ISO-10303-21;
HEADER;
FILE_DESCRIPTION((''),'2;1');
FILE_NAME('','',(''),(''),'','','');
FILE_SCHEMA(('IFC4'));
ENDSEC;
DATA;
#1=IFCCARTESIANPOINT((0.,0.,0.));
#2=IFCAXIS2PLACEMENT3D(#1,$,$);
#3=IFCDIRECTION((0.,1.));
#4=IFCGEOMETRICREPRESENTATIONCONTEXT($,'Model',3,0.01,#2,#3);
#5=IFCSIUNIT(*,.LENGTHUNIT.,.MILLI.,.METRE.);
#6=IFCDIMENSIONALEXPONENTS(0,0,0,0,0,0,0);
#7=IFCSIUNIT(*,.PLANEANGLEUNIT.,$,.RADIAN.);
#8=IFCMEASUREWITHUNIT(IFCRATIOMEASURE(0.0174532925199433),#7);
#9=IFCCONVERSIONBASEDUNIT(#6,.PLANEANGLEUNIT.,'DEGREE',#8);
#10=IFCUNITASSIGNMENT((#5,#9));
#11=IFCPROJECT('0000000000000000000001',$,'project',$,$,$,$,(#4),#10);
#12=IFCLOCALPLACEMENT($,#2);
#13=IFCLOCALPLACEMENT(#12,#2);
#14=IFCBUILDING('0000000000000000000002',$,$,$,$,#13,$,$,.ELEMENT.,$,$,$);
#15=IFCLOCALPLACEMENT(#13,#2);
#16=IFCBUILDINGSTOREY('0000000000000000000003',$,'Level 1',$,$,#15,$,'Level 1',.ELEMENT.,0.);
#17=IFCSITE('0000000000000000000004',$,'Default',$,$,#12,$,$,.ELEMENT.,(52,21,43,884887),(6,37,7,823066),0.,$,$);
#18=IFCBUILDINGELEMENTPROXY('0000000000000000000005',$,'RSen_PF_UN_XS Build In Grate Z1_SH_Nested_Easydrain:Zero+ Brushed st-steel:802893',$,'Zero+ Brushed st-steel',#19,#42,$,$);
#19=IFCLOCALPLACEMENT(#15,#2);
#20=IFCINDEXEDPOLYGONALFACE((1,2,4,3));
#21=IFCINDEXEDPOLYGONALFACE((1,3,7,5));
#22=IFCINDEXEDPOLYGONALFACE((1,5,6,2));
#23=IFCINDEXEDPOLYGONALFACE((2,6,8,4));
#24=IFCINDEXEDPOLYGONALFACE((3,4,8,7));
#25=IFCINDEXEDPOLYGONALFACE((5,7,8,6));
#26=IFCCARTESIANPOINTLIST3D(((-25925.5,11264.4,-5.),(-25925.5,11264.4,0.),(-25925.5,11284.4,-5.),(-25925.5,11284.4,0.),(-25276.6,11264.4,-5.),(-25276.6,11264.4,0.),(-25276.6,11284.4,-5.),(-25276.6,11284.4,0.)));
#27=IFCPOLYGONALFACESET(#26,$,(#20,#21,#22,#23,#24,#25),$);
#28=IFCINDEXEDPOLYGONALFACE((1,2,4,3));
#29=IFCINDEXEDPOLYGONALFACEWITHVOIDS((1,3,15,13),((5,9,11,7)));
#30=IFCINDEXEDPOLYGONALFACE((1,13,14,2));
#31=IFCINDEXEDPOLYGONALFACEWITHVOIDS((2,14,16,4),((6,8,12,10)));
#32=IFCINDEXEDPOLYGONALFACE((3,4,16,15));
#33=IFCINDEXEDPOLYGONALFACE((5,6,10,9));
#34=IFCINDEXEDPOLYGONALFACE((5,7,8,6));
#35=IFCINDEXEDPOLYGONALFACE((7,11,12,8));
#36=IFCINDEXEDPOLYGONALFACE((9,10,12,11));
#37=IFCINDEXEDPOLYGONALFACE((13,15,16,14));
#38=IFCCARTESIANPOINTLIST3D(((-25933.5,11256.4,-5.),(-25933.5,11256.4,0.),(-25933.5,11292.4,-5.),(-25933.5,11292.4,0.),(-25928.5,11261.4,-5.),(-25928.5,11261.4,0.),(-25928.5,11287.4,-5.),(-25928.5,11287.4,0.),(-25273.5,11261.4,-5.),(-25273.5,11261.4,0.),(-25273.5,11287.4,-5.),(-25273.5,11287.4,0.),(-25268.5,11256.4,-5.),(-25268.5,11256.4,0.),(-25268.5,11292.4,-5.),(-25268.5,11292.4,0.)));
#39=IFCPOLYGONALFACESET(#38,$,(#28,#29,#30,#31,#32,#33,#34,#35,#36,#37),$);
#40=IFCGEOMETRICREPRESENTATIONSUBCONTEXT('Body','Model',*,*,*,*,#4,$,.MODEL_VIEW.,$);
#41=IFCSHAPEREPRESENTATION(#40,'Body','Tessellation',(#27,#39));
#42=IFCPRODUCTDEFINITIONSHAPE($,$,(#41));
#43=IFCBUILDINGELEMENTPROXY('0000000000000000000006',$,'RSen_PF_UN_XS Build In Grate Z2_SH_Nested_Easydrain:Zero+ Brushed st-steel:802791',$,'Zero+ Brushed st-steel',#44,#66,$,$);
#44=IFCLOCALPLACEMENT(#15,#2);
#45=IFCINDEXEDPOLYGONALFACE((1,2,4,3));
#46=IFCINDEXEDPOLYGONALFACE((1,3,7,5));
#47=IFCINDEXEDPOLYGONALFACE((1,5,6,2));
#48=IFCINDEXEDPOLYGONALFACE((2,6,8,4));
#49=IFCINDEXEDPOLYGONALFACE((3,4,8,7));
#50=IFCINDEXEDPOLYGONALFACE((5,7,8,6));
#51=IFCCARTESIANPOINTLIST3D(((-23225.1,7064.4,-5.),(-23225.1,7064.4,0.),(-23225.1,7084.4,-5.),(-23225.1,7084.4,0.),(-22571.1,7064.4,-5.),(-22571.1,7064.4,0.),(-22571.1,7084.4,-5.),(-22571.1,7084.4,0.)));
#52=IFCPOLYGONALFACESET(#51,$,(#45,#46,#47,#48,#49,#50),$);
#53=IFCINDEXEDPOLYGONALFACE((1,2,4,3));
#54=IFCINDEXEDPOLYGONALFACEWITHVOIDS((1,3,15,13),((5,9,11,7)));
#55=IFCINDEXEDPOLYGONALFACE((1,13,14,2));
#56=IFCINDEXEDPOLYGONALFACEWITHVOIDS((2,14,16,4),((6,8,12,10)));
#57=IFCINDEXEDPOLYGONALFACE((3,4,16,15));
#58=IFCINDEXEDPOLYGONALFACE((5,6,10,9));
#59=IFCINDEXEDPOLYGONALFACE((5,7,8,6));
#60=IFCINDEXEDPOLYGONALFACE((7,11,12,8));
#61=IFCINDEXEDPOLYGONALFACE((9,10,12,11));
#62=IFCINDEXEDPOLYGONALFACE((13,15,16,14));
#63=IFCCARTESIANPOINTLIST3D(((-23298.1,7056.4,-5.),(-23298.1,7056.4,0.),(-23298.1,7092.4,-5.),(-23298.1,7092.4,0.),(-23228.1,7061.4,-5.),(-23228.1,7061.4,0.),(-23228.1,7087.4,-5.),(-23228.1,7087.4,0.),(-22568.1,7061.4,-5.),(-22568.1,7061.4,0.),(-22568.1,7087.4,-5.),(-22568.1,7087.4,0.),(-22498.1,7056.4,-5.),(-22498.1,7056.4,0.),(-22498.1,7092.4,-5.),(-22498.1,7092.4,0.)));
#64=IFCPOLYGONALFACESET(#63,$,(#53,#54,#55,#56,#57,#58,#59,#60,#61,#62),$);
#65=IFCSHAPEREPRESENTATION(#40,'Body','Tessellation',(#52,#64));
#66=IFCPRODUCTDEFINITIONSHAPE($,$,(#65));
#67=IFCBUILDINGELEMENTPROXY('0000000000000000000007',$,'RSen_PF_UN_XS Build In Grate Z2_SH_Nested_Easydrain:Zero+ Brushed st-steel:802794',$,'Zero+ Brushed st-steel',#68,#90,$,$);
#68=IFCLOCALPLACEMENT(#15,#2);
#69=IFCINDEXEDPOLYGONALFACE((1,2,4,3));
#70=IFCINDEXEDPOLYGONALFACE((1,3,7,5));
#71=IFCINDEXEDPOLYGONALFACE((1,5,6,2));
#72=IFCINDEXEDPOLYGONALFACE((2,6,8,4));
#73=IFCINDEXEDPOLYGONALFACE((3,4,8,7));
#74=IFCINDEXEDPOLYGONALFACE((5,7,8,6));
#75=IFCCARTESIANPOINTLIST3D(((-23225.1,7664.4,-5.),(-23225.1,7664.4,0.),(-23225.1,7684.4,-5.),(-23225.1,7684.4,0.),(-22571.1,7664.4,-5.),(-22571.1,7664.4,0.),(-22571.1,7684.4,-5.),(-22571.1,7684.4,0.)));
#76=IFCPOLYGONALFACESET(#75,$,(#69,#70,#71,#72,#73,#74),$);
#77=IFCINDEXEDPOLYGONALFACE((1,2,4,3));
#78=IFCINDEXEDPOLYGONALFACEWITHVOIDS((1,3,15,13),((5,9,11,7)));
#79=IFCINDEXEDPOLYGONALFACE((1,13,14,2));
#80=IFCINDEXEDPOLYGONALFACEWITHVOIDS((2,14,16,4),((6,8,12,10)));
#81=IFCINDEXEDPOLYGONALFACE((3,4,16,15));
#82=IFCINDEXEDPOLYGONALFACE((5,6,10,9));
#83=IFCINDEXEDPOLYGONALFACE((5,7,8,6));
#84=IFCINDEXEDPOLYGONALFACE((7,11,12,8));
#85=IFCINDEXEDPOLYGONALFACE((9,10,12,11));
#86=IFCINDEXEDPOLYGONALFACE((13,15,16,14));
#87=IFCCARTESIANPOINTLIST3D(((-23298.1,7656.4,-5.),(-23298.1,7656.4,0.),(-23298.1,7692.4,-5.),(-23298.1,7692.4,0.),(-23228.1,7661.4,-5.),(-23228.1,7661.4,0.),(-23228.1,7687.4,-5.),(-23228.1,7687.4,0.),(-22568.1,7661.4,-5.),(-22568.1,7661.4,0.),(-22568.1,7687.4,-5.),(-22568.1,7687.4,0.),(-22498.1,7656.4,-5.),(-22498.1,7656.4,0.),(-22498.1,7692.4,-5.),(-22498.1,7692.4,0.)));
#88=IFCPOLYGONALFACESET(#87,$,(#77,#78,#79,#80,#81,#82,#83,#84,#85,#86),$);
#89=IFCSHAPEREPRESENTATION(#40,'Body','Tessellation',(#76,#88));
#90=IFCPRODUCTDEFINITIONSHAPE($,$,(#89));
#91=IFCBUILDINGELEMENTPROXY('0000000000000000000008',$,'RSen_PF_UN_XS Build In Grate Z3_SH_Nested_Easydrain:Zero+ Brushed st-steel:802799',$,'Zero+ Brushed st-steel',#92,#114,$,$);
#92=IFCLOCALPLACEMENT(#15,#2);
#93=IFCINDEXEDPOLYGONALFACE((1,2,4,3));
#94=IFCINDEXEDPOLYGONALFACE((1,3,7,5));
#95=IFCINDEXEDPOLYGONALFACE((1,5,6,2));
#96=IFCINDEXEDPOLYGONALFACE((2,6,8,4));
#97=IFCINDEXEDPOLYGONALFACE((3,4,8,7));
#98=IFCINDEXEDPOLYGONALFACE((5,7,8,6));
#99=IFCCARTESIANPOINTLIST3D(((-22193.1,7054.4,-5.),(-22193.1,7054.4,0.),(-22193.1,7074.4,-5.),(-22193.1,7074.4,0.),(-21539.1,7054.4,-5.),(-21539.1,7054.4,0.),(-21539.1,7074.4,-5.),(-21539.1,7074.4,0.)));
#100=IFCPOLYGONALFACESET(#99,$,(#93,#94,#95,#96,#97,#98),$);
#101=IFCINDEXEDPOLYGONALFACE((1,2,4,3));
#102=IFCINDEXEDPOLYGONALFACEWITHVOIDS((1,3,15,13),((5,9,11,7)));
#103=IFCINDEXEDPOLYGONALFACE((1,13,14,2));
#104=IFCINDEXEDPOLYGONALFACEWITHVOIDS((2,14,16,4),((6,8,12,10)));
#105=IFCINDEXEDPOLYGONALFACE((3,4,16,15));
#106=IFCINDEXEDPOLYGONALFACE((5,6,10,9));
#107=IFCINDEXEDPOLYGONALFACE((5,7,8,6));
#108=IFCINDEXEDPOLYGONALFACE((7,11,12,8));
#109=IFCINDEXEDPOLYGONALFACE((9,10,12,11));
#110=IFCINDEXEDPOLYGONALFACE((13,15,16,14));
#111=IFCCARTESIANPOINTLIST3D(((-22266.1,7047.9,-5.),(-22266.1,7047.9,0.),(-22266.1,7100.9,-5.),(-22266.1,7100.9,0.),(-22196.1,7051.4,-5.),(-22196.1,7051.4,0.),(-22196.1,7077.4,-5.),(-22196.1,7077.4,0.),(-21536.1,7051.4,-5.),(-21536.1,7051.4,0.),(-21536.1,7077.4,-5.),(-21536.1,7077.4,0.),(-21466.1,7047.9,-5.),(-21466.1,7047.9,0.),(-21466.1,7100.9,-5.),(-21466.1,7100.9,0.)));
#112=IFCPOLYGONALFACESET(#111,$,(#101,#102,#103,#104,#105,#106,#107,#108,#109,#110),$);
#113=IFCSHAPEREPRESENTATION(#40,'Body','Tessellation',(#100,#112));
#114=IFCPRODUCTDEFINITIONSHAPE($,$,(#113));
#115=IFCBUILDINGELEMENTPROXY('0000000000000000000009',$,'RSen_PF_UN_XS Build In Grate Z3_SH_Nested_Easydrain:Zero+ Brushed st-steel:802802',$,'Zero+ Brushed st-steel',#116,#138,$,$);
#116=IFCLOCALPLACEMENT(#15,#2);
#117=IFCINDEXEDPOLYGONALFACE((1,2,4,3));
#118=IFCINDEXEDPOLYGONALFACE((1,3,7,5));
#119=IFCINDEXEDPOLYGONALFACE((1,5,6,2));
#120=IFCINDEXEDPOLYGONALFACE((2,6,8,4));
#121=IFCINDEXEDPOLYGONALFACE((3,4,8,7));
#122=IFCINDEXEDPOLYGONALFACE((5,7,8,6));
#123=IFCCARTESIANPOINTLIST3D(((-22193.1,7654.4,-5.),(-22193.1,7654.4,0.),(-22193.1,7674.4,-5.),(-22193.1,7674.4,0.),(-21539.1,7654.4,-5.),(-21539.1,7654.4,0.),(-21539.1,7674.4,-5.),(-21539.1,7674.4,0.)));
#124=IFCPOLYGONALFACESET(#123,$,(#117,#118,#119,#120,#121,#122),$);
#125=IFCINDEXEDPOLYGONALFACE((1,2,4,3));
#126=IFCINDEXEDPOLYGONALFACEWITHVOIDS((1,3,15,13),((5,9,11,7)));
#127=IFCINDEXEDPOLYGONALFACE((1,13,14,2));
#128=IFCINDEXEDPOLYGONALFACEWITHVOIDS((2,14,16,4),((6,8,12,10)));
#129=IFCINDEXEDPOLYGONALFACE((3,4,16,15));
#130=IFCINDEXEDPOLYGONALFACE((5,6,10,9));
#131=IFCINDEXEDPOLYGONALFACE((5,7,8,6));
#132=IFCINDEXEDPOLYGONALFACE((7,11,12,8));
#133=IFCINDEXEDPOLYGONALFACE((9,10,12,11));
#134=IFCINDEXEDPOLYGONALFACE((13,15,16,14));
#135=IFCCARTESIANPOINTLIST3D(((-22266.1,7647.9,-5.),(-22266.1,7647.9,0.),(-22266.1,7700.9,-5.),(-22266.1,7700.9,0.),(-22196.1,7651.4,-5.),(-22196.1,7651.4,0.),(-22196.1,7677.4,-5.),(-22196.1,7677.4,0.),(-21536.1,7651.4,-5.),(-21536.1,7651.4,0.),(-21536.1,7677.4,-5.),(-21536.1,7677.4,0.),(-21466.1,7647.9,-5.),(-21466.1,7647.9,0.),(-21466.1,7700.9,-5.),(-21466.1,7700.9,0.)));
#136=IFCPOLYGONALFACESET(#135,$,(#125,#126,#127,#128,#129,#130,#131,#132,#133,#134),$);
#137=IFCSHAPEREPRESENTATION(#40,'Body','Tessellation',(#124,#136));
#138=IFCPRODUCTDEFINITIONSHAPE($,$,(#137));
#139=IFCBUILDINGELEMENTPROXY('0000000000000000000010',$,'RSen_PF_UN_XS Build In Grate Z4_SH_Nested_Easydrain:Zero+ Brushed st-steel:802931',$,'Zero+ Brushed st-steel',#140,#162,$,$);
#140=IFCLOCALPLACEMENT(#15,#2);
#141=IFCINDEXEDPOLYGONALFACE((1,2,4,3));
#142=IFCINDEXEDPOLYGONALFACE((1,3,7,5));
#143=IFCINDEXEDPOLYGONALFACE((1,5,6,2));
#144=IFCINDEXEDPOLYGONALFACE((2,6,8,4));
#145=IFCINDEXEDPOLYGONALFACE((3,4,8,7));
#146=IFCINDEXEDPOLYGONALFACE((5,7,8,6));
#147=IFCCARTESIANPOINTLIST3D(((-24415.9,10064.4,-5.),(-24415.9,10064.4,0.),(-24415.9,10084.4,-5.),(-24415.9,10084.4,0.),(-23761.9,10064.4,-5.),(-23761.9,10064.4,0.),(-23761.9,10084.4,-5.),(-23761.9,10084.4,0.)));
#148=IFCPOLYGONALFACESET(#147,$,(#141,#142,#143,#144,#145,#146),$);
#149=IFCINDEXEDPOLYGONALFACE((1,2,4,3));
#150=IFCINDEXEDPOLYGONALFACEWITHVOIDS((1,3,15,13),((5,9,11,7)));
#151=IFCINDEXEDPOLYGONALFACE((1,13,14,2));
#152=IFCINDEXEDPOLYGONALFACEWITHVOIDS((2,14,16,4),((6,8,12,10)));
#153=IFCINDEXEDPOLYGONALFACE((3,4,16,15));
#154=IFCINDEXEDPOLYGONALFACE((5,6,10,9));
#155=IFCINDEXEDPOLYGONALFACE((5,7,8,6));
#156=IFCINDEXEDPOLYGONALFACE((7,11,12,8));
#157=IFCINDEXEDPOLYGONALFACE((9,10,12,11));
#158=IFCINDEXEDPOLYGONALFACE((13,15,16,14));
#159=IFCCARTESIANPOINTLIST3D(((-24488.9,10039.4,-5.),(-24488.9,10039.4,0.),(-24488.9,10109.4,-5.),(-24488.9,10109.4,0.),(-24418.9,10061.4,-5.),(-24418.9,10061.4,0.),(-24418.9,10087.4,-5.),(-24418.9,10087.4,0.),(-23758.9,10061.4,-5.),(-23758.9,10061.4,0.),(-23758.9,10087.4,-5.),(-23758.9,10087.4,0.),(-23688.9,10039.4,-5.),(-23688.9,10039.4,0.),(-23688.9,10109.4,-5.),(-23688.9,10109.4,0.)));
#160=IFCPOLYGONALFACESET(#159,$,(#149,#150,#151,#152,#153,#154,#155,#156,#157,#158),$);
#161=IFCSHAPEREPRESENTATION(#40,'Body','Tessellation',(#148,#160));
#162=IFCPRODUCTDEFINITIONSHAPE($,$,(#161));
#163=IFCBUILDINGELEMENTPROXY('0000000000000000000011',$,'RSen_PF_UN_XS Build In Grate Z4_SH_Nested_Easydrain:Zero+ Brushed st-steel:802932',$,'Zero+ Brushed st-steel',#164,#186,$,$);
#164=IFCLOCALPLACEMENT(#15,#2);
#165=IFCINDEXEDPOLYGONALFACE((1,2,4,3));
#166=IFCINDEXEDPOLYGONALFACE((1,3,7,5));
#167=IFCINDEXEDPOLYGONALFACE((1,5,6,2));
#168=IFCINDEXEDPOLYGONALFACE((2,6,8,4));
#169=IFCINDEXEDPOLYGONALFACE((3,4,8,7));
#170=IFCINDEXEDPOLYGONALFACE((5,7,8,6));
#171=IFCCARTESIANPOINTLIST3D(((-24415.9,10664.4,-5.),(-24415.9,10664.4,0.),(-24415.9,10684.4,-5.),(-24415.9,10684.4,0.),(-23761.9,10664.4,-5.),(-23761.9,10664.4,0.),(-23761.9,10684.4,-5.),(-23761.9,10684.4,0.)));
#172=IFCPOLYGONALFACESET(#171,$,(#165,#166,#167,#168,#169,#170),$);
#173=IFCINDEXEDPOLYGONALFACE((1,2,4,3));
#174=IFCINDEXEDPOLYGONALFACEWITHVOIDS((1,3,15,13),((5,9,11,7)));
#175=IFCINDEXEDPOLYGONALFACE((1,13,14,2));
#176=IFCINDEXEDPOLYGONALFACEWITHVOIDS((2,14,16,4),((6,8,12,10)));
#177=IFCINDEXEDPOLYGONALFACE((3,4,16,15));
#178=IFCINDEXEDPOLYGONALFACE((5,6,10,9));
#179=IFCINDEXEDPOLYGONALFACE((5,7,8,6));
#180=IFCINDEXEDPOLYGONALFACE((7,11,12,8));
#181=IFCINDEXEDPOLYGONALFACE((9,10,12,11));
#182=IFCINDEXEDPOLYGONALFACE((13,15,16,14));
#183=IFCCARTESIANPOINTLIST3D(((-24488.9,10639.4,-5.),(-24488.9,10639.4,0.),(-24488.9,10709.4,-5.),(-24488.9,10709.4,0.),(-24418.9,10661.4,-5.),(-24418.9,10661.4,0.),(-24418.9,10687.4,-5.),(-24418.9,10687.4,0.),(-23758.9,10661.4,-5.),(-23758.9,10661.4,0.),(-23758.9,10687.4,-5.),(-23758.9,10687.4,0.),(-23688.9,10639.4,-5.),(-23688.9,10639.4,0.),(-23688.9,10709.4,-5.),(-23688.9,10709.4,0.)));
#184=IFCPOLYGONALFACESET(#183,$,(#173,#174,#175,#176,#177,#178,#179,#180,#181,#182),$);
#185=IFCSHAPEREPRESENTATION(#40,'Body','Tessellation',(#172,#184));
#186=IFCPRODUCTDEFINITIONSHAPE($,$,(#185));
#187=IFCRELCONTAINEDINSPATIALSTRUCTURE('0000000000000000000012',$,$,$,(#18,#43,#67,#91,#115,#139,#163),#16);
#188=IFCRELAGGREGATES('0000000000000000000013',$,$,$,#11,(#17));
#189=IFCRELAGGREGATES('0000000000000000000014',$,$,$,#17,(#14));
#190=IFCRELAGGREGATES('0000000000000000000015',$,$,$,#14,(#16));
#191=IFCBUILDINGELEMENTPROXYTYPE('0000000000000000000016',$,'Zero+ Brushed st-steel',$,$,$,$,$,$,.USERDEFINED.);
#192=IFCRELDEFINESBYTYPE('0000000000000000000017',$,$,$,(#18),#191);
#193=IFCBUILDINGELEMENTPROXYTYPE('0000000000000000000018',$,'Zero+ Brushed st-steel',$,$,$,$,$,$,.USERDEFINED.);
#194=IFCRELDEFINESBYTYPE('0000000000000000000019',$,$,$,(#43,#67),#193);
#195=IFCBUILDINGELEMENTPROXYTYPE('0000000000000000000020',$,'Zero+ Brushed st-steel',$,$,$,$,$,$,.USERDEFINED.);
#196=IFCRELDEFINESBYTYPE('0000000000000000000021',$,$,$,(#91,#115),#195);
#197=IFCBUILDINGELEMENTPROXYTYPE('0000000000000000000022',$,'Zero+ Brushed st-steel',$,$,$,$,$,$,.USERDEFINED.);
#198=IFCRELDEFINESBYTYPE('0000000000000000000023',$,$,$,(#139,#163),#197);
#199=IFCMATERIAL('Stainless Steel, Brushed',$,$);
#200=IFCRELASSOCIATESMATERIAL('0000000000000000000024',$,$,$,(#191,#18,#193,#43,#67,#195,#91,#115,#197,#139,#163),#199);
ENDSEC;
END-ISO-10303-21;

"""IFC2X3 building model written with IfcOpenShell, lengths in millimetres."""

from ifc_helpers import new_model, entity, si_unit, converted_unit, direction, frame, origin, origin_2d_with_axis, place, context, subcontext, project, spatial, polyline, rectangle, outline, extrude, source, transform, mapped, material, type_object, type_shapes, element, save


model = new_model("IFC2X3")

# Units and contexts
model_context = context("Model", 3, precision=0.01, world=origin(), true_north=direction((0.0, 1.0)))
body_context = subcontext(model_context, "Body", "Model", "MODEL_VIEW")
ifc_project = project(units=[si_unit("LENGTHUNIT", "METRE", prefix="MILLI"), converted_unit("PLANEANGLEUNIT", "DEGREE", entity("IfcRatioMeasure", 0.0174532925199433), si_unit("PLANEANGLEUNIT", "RADIAN"), dimensions=[0, 0, 0, 0, 0, 0, 0])], contexts=[model_context])

# Site, building, storey
site_placement = place(None, origin())
site = spatial("IfcSite", under=ifc_project, at=site_placement, Name="Default", CompositionType="ELEMENT", RefLatitude=(52, 21, 43, 884887), RefLongitude=(6, 37, 7, 823066), RefElevation=0.0)
building_placement = place(site_placement, origin())
building = spatial("IfcBuilding", under=site, at=building_placement, CompositionType="ELEMENT")
storey_placement = place(building_placement, origin())
storey = spatial("IfcBuildingStorey", under=building, at=storey_placement, Name="Level 1", LongName="Level 1", CompositionType="ELEMENT", Elevation=0.0)

# Shared definitions
ifc_material_1 = material(Name="Stainless Steel, Brushed")

# Building element proxies
building_element_proxy_type_1 = type_object("IfcBuildingElementProxyType", Name="Zero+ Brushed st-steel", PredefinedType="USERDEFINED", material=ifc_material_1)
shared_shape_1 = source(origin(), body_context, "Body", "SweptSolid", [
    extrude(rectangle(XDim=649.0, YDim=20.0, at=origin_2d_with_axis()), frame((0.0, 0.0, 0.0), z_axis=(0.0, 0.0, 1.0), x_axis=(-1.0, 0.0, 0.0)), (0.0, 0.0, 1.0), 5.0),
    extrude(outline(polyline([(-332.5, -18.0), (332.5, -18.0), (332.5, 18.0), (-332.5, 18.0), (-332.5, -18.0)]), holes=[polyline([(-327.5, -13.0), (-327.5, 13.0), (327.5, 13.0), (327.5, -13.0), (-327.5, -13.0)])]), frame((0.0, 0.0, 0.0), z_axis=(0.0, 0.0, 1.0), x_axis=(-1.0, 0.0, 0.0)), (0.0, 0.0, 1.0), 5.0),
])
type_shapes(building_element_proxy_type_1, [shared_shape_1])
for number, where, name in (
    (1, (-25601.0, 11274.4, -5.0), "RSen_PF_UN_XS Build In Grate Z1_SH_Nested_Easydrain:Zero+ Brushed st-steel:802893"),
):
    element("IfcBuildingElementProxy", number, at=place(storey_placement, frame(where)), inside=storey, type_object=building_element_proxy_type_1, material=ifc_material_1, Name=name, ObjectType="Zero+ Brushed st-steel", context=body_context, shape_type="MappedRepresentation", body=[
        mapped(shared_shape_1, transform((0.0, 0.0, 0.0), scale=1.0)),
    ])
building_element_proxy_type_2 = type_object("IfcBuildingElementProxyType", Name="Zero+ Brushed st-steel", PredefinedType="USERDEFINED", material=ifc_material_1)
shared_shape_2 = source(origin(), body_context, "Body", "SweptSolid", [
    extrude(rectangle(XDim=654.0, YDim=20.0, at=origin_2d_with_axis()), frame((0.0, 0.0, 0.0), z_axis=(0.0, 0.0, 1.0), x_axis=(-1.0, 0.0, 0.0)), (0.0, 0.0, 1.0), 5.0),
    extrude(outline(polyline([(-400.0, -18.0), (400.0, -18.0), (400.0, 18.0), (-400.0, 18.0), (-400.0, -18.0)]), holes=[polyline([(-330.0, -13.0), (-330.0, 13.0), (330.0, 13.0), (330.0, -13.0), (-330.0, -13.0)])]), frame((0.0, 0.0, 0.0), z_axis=(0.0, 0.0, 1.0), x_axis=(-1.0, 0.0, 0.0)), (0.0, 0.0, 1.0), 5.0),
])
type_shapes(building_element_proxy_type_2, [shared_shape_2])
for number, where, name in (
    (2, (-22898.1, 7074.4, -5.0), "RSen_PF_UN_XS Build In Grate Z2_SH_Nested_Easydrain:Zero+ Brushed st-steel:802791"),
    (3, (-22898.1, 7674.4, -5.0), "RSen_PF_UN_XS Build In Grate Z2_SH_Nested_Easydrain:Zero+ Brushed st-steel:802794"),
):
    element("IfcBuildingElementProxy", number, at=place(storey_placement, frame(where)), inside=storey, type_object=building_element_proxy_type_2, material=ifc_material_1, Name=name, ObjectType="Zero+ Brushed st-steel", context=body_context, shape_type="MappedRepresentation", body=[
        mapped(shared_shape_2, transform((0.0, 0.0, 0.0), scale=1.0)),
    ])
building_element_proxy_type_3 = type_object("IfcBuildingElementProxyType", Name="Zero+ Brushed st-steel", PredefinedType="USERDEFINED", material=ifc_material_1)
shared_shape_3 = source(origin(), body_context, "Body", "SweptSolid", [
    extrude(rectangle(XDim=654.0, YDim=20.0, at=origin_2d_with_axis()), frame((0.0, -10.0, 0.0), z_axis=(0.0, 0.0, 1.0), x_axis=(-1.0, 0.0, 0.0)), (0.0, 0.0, 1.0), 5.0),
    extrude(outline(polyline([(-400.0, -26.5), (400.0, -26.5), (400.0, 26.5), (-400.0, 26.5), (-400.0, -26.5)]), holes=[polyline([(-330.0, -3.0), (-330.0, 23.0), (330.0, 23.0), (330.0, -3.0), (-330.0, -3.0)])]), frame((0.0, 0.0, 0.0), z_axis=(0.0, 0.0, 1.0), x_axis=(-1.0, 0.0, 0.0)), (0.0, 0.0, 1.0), 5.0),
])
type_shapes(building_element_proxy_type_3, [shared_shape_3])
for number, where, name in (
    (4, (-21866.1, 7074.4, -5.0), "RSen_PF_UN_XS Build In Grate Z3_SH_Nested_Easydrain:Zero+ Brushed st-steel:802799"),
    (5, (-21866.1, 7674.4, -5.0), "RSen_PF_UN_XS Build In Grate Z3_SH_Nested_Easydrain:Zero+ Brushed st-steel:802802"),
):
    element("IfcBuildingElementProxy", number, at=place(storey_placement, frame(where)), inside=storey, type_object=building_element_proxy_type_3, material=ifc_material_1, Name=name, ObjectType="Zero+ Brushed st-steel", context=body_context, shape_type="MappedRepresentation", body=[
        mapped(shared_shape_3, transform((0.0, 0.0, 0.0), scale=1.0)),
    ])
building_element_proxy_type_4 = type_object("IfcBuildingElementProxyType", Name="Zero+ Brushed st-steel", PredefinedType="USERDEFINED", material=ifc_material_1)
shared_shape_4 = source(origin(), body_context, "Body", "SweptSolid", [
    extrude(rectangle(XDim=654.0, YDim=20.0, at=origin_2d_with_axis()), frame((0.0, 0.0, 0.0), z_axis=(0.0, 0.0, 1.0), x_axis=(-1.0, 0.0, 0.0)), (0.0, 0.0, 1.0), 5.0),
    extrude(outline(polyline([(-400.0, -35.0), (400.0, -35.0), (400.0, 35.0), (-400.0, 35.0), (-400.0, -35.0)]), holes=[polyline([(-330.0, -13.0), (-330.0, 13.0), (330.0, 13.0), (330.0, -13.0), (-330.0, -13.0)])]), frame((0.0, 0.0, 0.0), z_axis=(0.0, 0.0, 1.0), x_axis=(-1.0, 0.0, 0.0)), (0.0, 0.0, 1.0), 5.0),
])
type_shapes(building_element_proxy_type_4, [shared_shape_4])
for number, where, name in (
    (6, (-24088.9, 10074.4, -5.0), "RSen_PF_UN_XS Build In Grate Z4_SH_Nested_Easydrain:Zero+ Brushed st-steel:802931"),
    (7, (-24088.9, 10674.4, -5.0), "RSen_PF_UN_XS Build In Grate Z4_SH_Nested_Easydrain:Zero+ Brushed st-steel:802932"),
):
    element("IfcBuildingElementProxy", number, at=place(storey_placement, frame(where)), inside=storey, type_object=building_element_proxy_type_4, material=ifc_material_1, Name=name, ObjectType="Zero+ Brushed st-steel", context=body_context, shape_type="MappedRepresentation", body=[
        mapped(shared_shape_4, transform((0.0, 0.0, 0.0), scale=1.0)),
    ])

save(model, "model.ifc")
